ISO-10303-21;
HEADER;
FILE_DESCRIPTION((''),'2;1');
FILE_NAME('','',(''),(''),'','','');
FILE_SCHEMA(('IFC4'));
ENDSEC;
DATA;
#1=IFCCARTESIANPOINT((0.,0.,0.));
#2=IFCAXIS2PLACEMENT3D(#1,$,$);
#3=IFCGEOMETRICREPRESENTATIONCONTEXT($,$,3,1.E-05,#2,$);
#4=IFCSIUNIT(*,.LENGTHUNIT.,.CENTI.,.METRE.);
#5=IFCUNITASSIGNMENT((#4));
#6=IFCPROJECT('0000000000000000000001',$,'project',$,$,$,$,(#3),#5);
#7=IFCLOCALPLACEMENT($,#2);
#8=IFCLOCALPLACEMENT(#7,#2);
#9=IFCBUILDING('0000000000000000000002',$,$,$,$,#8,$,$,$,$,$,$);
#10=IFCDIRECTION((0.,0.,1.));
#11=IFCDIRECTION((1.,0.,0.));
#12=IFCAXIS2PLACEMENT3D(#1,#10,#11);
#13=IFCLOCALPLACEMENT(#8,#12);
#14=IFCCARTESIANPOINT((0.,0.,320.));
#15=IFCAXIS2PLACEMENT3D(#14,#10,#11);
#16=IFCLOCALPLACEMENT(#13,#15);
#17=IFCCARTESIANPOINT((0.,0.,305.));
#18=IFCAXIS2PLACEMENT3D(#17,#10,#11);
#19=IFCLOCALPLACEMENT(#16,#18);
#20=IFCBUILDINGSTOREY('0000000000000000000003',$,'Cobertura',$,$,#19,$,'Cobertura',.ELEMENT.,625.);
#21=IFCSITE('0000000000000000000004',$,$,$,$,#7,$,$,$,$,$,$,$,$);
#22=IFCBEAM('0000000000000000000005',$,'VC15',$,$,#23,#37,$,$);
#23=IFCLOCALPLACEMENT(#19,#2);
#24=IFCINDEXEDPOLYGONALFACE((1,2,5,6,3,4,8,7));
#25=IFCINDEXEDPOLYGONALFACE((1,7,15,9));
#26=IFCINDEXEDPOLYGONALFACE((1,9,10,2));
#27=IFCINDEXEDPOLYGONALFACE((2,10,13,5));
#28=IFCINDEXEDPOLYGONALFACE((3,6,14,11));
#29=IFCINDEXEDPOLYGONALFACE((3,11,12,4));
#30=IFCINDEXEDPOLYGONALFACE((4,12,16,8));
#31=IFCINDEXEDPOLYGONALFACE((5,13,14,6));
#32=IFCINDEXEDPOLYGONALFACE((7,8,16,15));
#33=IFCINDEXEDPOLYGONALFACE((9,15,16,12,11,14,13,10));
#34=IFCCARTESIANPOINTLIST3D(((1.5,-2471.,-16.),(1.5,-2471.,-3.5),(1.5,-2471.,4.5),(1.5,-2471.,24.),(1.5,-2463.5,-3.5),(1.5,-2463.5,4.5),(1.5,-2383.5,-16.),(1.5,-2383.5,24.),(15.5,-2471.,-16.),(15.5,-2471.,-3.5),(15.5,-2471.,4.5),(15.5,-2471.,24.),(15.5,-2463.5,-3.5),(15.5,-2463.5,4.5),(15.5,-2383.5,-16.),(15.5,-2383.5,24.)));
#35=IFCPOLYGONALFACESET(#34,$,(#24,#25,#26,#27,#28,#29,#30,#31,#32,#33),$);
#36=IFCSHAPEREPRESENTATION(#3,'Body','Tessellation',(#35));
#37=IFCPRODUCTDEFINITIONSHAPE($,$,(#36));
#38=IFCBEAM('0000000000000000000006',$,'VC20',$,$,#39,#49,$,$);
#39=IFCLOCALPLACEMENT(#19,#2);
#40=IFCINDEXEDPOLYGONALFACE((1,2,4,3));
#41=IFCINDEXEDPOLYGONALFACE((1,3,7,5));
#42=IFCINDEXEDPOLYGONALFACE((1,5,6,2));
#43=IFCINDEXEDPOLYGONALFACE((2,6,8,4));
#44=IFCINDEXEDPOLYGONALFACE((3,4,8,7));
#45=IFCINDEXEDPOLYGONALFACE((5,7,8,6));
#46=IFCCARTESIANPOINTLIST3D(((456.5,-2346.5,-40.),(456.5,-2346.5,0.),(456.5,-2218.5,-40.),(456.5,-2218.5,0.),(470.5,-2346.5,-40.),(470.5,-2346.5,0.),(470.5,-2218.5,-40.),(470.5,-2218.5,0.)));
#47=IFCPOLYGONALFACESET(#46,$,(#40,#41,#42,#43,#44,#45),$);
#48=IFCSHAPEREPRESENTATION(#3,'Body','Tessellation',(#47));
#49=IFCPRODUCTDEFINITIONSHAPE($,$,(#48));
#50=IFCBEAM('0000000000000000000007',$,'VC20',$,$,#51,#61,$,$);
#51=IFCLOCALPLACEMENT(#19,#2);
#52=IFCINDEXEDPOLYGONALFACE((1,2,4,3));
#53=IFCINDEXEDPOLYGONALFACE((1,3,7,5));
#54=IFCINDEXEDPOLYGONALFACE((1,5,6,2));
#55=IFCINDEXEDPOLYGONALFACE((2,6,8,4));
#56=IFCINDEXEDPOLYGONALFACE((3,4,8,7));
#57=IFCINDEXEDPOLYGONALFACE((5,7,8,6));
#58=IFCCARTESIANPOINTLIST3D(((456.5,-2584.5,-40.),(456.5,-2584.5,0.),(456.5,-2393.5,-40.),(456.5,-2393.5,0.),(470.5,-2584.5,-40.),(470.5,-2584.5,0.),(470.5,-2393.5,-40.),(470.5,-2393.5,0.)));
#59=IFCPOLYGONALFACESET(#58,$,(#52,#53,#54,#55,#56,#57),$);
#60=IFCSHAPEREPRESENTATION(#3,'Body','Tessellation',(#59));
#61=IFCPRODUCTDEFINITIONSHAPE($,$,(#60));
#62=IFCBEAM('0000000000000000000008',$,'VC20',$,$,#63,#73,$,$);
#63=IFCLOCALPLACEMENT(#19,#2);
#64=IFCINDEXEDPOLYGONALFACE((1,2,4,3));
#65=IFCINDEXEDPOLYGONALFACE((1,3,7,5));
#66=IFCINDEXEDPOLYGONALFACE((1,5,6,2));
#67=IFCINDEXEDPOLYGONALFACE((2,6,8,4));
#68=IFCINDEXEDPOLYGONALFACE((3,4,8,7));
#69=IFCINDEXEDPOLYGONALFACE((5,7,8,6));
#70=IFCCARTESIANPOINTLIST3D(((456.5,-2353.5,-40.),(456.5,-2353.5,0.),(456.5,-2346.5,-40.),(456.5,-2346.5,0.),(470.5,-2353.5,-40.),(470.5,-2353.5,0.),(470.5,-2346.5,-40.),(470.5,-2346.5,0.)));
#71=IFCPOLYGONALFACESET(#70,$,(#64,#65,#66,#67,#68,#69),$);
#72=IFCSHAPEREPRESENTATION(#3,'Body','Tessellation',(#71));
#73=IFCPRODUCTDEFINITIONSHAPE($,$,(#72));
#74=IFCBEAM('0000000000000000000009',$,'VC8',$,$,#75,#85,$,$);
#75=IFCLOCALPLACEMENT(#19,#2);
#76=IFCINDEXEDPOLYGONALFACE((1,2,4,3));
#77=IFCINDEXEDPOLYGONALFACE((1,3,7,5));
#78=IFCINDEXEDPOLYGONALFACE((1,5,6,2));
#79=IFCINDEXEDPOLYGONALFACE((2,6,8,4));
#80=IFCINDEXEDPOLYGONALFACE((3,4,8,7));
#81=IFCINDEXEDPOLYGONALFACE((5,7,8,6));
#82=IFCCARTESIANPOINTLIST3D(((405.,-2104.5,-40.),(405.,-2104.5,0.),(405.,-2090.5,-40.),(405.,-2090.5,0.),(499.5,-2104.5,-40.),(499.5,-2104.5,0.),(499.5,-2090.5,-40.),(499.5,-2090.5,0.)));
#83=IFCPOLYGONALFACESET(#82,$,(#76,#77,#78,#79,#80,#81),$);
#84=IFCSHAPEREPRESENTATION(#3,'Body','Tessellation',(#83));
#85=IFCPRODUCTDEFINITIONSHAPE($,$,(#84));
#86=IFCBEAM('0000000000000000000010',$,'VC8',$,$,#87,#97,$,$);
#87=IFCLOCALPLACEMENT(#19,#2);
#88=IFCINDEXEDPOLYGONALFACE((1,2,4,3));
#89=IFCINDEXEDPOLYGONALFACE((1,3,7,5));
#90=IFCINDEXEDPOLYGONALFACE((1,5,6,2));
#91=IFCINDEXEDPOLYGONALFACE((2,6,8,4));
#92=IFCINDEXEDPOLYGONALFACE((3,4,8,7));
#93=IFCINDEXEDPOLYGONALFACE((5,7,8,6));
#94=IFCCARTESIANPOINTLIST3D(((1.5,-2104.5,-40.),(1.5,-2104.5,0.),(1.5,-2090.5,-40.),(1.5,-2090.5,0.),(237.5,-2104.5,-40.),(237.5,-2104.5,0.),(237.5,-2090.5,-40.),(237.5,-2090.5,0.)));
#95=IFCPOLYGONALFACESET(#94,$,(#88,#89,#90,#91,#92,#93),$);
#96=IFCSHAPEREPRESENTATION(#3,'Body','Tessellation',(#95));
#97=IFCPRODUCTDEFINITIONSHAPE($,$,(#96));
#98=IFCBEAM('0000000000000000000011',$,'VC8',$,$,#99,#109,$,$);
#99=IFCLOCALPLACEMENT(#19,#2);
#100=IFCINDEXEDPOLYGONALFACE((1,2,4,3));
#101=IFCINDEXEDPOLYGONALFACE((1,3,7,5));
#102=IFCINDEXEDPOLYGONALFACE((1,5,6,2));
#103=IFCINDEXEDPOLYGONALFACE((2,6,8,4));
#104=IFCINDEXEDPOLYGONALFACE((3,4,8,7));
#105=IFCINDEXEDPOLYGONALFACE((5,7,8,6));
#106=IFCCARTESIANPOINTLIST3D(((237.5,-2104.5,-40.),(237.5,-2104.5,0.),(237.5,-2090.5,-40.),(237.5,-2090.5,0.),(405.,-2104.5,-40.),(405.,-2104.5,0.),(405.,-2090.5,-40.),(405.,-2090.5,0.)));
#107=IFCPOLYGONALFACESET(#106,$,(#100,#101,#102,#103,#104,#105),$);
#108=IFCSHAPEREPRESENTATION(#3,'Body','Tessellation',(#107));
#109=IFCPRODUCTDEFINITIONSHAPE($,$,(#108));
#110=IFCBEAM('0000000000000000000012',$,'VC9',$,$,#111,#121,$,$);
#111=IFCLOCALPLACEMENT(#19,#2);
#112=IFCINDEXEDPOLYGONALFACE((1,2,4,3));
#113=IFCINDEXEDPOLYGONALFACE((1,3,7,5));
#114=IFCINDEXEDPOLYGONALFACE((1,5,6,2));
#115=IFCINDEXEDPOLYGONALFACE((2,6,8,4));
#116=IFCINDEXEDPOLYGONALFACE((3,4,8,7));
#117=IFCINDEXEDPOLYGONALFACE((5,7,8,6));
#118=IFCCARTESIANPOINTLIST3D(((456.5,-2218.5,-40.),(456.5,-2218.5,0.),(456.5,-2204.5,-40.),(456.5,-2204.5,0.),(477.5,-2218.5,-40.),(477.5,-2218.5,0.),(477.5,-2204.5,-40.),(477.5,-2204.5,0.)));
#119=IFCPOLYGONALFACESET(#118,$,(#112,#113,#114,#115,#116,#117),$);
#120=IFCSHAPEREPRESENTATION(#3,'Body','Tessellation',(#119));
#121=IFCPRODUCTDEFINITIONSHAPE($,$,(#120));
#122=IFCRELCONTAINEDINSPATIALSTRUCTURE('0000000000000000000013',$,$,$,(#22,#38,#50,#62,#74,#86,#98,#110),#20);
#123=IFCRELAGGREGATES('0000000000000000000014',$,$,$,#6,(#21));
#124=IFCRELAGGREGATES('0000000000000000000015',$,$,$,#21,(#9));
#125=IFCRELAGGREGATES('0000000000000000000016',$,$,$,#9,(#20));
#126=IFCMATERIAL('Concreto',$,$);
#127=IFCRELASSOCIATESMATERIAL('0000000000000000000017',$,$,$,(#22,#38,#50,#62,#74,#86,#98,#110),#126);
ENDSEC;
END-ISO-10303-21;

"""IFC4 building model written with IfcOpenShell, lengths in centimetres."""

from ifc_helpers import new_model, si_unit, frame, origin, origin_with_axes, place, context, project, spatial, polyline, outline, extrude, material, element, save


model = new_model("IFC4")

# Units and contexts
context_of_model = context(None, 3, precision=1e-05, world=origin())
ifc_project = project(units=[si_unit("LENGTHUNIT", "METRE", prefix="CENTI")], contexts=[context_of_model])

# Site, building, storey
site_placement = place(None, origin())
site = spatial("IfcSite", under=ifc_project, at=site_placement)
building_placement = place(site_placement, origin())
building = spatial("IfcBuilding", under=site, at=building_placement)
placement_1 = place(building_placement, origin_with_axes())
placement_2 = place(placement_1, frame((0.0, 0.0, 320.0), z_axis=(0.0, 0.0, 1.0), x_axis=(1.0, 0.0, 0.0)))
storey_placement = place(placement_2, frame((0.0, 0.0, 305.0), z_axis=(0.0, 0.0, 1.0), x_axis=(1.0, 0.0, 0.0)))
storey = spatial("IfcBuildingStorey", under=building, at=storey_placement, Name="Cobertura", LongName="Cobertura", CompositionType="ELEMENT", Elevation=625.0)

# Shared definitions
ifc_material = material(Name="Concreto")

# Beam, opening
beam_1_placement = place(storey_placement, frame((8.5, -2427.25, 24.0), z_axis=(0.0, 0.0, 1.0), x_axis=(1.0, 0.0, 0.0)))
beam_1 = element("IfcBeam", 1, at=beam_1_placement, inside=storey, material=ifc_material, Name="VC15", context=context_of_model, shape_type="SolidModel", body=[
    extrude(outline(polyline([(-7.0, -20.0), (7.0, -20.0), (7.0, 20.0), (-7.0, 20.0), (-7.0, -20.0)])), frame((0.0, -43.75, -20.0), z_axis=(0.0, 1.0, 0.0), x_axis=(1.0, 0.0, 0.0)), (0.0, 0.0, 1.0), 87.5),
])
opening_1_placement = place(storey_placement, frame((0.0, 0.0, -625.0), z_axis=(0.0, 0.0, 1.0), x_axis=(1.0, 0.0, 0.0)))
element("IfcOpeningElement", 2, at=opening_1_placement, cuts=beam_1, material=ifc_material, context=context_of_model, shape_type="SweptSolid", body=[
    extrude(outline(polyline([(7.5, 4.0), (-7.5, 4.0), (-7.5, -4.0), (7.5, -4.0), (7.5, 4.0)])), frame((15.5, -2471.0, 625.5), z_axis=(-1.0, 0.0, 0.0), x_axis=(0.0, -1.0, 0.0)), (0.0, 0.0, 1.0), 14.0),
])

# Beams
beam_2_placement = place(storey_placement, frame((463.5, -2282.5, 0.0), z_axis=(0.0, 0.0, 1.0), x_axis=(1.0, 0.0, 0.0)))
element("IfcBeam", 3, at=beam_2_placement, inside=storey, material=ifc_material, Name="VC20", context=context_of_model, shape_type="SolidModel", body=[
    extrude(outline(polyline([(-7.0, -20.0), (7.0, -20.0), (7.0, 20.0), (-7.0, 20.0), (-7.0, -20.0)])), frame((0.0, -64.0, -20.0), z_axis=(0.0, 1.0, 0.0), x_axis=(1.0, 0.0, 0.0)), (0.0, 0.0, 1.0), 128.0),
])
beam_3_placement = place(storey_placement, frame((463.5, -2489.0, 0.0), z_axis=(0.0, 0.0, 1.0), x_axis=(1.0, 0.0, 0.0)))
element("IfcBeam", 4, at=beam_3_placement, inside=storey, material=ifc_material, Name="VC20", context=context_of_model, shape_type="SolidModel", body=[
    extrude(outline(polyline([(-7.0, -20.0), (7.0, -20.0), (7.0, 20.0), (-7.0, 20.0), (-7.0, -20.0)])), frame((0.0, -95.5, -20.0), z_axis=(0.0, 1.0, 0.0), x_axis=(1.0, 0.0, 0.0)), (0.0, 0.0, 1.0), 191.0),
])
beam_4_placement = place(storey_placement, frame((463.5, -2350.0, 0.0), z_axis=(0.0, 0.0, 1.0), x_axis=(1.0, 0.0, 0.0)))
element("IfcBeam", 5, at=beam_4_placement, inside=storey, material=ifc_material, Name="VC20", context=context_of_model, shape_type="SolidModel", body=[
    extrude(outline(polyline([(-7.0, -20.0), (7.0, -20.0), (7.0, 20.0), (-7.0, 20.0), (-7.0, -20.0)])), frame((0.0, -3.5, -20.0), z_axis=(0.0, 1.0, 0.0), x_axis=(1.0, 0.0, 0.0)), (0.0, 0.0, 1.0), 7.0),
])
beam_5_placement = place(storey_placement, frame((452.25, -2097.5, 0.0), z_axis=(0.0, 0.0, 1.0), x_axis=(1.0, 0.0, 0.0)))
element("IfcBeam", 6, at=beam_5_placement, inside=storey, material=ifc_material, Name="VC8", context=context_of_model, shape_type="SolidModel", body=[
    extrude(outline(polyline([(-7.0, -20.0), (7.0, -20.0), (7.0, 20.0), (-7.0, 20.0), (-7.0, -20.0)])), frame((-47.25, 0.0, -20.0), z_axis=(1.0, 0.0, 0.0), x_axis=(0.0, -1.0, 0.0)), (0.0, 0.0, 1.0), 94.5),
])
beam_6_placement = place(storey_placement, frame((119.5, -2097.5, 0.0), z_axis=(0.0, 0.0, 1.0), x_axis=(1.0, 0.0, 0.0)))
element("IfcBeam", 7, at=beam_6_placement, inside=storey, material=ifc_material, Name="VC8", context=context_of_model, shape_type="SolidModel", body=[
    extrude(outline(polyline([(-7.0, -20.0), (7.0, -20.0), (7.0, 20.0), (-7.0, 20.0), (-7.0, -20.0)])), frame((-118.0, 0.0, -20.0), z_axis=(1.0, 0.0, 0.0), x_axis=(0.0, -1.0, 0.0)), (0.0, 0.0, 1.0), 236.0),
])
beam_7_placement = place(storey_placement, frame((321.25, -2097.5, 0.0), z_axis=(0.0, 0.0, 1.0), x_axis=(1.0, 0.0, 0.0)))
element("IfcBeam", 8, at=beam_7_placement, inside=storey, material=ifc_material, Name="VC8", context=context_of_model, shape_type="SolidModel", body=[
    extrude(outline(polyline([(-7.0, -20.0), (7.0, -20.0), (7.0, 20.0), (-7.0, 20.0), (-7.0, -20.0)])), frame((-83.75, 0.0, -20.0), z_axis=(1.0, 0.0, 0.0), x_axis=(0.0, -1.0, 0.0)), (0.0, 0.0, 1.0), 167.5),
])
beam_8_placement = place(storey_placement, frame((467.0, -2211.5, 0.0), z_axis=(0.0, 0.0, 1.0), x_axis=(1.0, 0.0, 0.0)))
element("IfcBeam", 9, at=beam_8_placement, inside=storey, material=ifc_material, Name="VC9", context=context_of_model, shape_type="SolidModel", body=[
    extrude(outline(polyline([(-7.0, -20.0), (7.0, -20.0), (7.0, 20.0), (-7.0, 20.0), (-7.0, -20.0)])), frame((-10.5, 0.0, -20.0), z_axis=(1.0, 0.0, 0.0), x_axis=(0.0, -1.0, 0.0)), (0.0, 0.0, 1.0), 21.0),
])

save(model, "model.ifc")
